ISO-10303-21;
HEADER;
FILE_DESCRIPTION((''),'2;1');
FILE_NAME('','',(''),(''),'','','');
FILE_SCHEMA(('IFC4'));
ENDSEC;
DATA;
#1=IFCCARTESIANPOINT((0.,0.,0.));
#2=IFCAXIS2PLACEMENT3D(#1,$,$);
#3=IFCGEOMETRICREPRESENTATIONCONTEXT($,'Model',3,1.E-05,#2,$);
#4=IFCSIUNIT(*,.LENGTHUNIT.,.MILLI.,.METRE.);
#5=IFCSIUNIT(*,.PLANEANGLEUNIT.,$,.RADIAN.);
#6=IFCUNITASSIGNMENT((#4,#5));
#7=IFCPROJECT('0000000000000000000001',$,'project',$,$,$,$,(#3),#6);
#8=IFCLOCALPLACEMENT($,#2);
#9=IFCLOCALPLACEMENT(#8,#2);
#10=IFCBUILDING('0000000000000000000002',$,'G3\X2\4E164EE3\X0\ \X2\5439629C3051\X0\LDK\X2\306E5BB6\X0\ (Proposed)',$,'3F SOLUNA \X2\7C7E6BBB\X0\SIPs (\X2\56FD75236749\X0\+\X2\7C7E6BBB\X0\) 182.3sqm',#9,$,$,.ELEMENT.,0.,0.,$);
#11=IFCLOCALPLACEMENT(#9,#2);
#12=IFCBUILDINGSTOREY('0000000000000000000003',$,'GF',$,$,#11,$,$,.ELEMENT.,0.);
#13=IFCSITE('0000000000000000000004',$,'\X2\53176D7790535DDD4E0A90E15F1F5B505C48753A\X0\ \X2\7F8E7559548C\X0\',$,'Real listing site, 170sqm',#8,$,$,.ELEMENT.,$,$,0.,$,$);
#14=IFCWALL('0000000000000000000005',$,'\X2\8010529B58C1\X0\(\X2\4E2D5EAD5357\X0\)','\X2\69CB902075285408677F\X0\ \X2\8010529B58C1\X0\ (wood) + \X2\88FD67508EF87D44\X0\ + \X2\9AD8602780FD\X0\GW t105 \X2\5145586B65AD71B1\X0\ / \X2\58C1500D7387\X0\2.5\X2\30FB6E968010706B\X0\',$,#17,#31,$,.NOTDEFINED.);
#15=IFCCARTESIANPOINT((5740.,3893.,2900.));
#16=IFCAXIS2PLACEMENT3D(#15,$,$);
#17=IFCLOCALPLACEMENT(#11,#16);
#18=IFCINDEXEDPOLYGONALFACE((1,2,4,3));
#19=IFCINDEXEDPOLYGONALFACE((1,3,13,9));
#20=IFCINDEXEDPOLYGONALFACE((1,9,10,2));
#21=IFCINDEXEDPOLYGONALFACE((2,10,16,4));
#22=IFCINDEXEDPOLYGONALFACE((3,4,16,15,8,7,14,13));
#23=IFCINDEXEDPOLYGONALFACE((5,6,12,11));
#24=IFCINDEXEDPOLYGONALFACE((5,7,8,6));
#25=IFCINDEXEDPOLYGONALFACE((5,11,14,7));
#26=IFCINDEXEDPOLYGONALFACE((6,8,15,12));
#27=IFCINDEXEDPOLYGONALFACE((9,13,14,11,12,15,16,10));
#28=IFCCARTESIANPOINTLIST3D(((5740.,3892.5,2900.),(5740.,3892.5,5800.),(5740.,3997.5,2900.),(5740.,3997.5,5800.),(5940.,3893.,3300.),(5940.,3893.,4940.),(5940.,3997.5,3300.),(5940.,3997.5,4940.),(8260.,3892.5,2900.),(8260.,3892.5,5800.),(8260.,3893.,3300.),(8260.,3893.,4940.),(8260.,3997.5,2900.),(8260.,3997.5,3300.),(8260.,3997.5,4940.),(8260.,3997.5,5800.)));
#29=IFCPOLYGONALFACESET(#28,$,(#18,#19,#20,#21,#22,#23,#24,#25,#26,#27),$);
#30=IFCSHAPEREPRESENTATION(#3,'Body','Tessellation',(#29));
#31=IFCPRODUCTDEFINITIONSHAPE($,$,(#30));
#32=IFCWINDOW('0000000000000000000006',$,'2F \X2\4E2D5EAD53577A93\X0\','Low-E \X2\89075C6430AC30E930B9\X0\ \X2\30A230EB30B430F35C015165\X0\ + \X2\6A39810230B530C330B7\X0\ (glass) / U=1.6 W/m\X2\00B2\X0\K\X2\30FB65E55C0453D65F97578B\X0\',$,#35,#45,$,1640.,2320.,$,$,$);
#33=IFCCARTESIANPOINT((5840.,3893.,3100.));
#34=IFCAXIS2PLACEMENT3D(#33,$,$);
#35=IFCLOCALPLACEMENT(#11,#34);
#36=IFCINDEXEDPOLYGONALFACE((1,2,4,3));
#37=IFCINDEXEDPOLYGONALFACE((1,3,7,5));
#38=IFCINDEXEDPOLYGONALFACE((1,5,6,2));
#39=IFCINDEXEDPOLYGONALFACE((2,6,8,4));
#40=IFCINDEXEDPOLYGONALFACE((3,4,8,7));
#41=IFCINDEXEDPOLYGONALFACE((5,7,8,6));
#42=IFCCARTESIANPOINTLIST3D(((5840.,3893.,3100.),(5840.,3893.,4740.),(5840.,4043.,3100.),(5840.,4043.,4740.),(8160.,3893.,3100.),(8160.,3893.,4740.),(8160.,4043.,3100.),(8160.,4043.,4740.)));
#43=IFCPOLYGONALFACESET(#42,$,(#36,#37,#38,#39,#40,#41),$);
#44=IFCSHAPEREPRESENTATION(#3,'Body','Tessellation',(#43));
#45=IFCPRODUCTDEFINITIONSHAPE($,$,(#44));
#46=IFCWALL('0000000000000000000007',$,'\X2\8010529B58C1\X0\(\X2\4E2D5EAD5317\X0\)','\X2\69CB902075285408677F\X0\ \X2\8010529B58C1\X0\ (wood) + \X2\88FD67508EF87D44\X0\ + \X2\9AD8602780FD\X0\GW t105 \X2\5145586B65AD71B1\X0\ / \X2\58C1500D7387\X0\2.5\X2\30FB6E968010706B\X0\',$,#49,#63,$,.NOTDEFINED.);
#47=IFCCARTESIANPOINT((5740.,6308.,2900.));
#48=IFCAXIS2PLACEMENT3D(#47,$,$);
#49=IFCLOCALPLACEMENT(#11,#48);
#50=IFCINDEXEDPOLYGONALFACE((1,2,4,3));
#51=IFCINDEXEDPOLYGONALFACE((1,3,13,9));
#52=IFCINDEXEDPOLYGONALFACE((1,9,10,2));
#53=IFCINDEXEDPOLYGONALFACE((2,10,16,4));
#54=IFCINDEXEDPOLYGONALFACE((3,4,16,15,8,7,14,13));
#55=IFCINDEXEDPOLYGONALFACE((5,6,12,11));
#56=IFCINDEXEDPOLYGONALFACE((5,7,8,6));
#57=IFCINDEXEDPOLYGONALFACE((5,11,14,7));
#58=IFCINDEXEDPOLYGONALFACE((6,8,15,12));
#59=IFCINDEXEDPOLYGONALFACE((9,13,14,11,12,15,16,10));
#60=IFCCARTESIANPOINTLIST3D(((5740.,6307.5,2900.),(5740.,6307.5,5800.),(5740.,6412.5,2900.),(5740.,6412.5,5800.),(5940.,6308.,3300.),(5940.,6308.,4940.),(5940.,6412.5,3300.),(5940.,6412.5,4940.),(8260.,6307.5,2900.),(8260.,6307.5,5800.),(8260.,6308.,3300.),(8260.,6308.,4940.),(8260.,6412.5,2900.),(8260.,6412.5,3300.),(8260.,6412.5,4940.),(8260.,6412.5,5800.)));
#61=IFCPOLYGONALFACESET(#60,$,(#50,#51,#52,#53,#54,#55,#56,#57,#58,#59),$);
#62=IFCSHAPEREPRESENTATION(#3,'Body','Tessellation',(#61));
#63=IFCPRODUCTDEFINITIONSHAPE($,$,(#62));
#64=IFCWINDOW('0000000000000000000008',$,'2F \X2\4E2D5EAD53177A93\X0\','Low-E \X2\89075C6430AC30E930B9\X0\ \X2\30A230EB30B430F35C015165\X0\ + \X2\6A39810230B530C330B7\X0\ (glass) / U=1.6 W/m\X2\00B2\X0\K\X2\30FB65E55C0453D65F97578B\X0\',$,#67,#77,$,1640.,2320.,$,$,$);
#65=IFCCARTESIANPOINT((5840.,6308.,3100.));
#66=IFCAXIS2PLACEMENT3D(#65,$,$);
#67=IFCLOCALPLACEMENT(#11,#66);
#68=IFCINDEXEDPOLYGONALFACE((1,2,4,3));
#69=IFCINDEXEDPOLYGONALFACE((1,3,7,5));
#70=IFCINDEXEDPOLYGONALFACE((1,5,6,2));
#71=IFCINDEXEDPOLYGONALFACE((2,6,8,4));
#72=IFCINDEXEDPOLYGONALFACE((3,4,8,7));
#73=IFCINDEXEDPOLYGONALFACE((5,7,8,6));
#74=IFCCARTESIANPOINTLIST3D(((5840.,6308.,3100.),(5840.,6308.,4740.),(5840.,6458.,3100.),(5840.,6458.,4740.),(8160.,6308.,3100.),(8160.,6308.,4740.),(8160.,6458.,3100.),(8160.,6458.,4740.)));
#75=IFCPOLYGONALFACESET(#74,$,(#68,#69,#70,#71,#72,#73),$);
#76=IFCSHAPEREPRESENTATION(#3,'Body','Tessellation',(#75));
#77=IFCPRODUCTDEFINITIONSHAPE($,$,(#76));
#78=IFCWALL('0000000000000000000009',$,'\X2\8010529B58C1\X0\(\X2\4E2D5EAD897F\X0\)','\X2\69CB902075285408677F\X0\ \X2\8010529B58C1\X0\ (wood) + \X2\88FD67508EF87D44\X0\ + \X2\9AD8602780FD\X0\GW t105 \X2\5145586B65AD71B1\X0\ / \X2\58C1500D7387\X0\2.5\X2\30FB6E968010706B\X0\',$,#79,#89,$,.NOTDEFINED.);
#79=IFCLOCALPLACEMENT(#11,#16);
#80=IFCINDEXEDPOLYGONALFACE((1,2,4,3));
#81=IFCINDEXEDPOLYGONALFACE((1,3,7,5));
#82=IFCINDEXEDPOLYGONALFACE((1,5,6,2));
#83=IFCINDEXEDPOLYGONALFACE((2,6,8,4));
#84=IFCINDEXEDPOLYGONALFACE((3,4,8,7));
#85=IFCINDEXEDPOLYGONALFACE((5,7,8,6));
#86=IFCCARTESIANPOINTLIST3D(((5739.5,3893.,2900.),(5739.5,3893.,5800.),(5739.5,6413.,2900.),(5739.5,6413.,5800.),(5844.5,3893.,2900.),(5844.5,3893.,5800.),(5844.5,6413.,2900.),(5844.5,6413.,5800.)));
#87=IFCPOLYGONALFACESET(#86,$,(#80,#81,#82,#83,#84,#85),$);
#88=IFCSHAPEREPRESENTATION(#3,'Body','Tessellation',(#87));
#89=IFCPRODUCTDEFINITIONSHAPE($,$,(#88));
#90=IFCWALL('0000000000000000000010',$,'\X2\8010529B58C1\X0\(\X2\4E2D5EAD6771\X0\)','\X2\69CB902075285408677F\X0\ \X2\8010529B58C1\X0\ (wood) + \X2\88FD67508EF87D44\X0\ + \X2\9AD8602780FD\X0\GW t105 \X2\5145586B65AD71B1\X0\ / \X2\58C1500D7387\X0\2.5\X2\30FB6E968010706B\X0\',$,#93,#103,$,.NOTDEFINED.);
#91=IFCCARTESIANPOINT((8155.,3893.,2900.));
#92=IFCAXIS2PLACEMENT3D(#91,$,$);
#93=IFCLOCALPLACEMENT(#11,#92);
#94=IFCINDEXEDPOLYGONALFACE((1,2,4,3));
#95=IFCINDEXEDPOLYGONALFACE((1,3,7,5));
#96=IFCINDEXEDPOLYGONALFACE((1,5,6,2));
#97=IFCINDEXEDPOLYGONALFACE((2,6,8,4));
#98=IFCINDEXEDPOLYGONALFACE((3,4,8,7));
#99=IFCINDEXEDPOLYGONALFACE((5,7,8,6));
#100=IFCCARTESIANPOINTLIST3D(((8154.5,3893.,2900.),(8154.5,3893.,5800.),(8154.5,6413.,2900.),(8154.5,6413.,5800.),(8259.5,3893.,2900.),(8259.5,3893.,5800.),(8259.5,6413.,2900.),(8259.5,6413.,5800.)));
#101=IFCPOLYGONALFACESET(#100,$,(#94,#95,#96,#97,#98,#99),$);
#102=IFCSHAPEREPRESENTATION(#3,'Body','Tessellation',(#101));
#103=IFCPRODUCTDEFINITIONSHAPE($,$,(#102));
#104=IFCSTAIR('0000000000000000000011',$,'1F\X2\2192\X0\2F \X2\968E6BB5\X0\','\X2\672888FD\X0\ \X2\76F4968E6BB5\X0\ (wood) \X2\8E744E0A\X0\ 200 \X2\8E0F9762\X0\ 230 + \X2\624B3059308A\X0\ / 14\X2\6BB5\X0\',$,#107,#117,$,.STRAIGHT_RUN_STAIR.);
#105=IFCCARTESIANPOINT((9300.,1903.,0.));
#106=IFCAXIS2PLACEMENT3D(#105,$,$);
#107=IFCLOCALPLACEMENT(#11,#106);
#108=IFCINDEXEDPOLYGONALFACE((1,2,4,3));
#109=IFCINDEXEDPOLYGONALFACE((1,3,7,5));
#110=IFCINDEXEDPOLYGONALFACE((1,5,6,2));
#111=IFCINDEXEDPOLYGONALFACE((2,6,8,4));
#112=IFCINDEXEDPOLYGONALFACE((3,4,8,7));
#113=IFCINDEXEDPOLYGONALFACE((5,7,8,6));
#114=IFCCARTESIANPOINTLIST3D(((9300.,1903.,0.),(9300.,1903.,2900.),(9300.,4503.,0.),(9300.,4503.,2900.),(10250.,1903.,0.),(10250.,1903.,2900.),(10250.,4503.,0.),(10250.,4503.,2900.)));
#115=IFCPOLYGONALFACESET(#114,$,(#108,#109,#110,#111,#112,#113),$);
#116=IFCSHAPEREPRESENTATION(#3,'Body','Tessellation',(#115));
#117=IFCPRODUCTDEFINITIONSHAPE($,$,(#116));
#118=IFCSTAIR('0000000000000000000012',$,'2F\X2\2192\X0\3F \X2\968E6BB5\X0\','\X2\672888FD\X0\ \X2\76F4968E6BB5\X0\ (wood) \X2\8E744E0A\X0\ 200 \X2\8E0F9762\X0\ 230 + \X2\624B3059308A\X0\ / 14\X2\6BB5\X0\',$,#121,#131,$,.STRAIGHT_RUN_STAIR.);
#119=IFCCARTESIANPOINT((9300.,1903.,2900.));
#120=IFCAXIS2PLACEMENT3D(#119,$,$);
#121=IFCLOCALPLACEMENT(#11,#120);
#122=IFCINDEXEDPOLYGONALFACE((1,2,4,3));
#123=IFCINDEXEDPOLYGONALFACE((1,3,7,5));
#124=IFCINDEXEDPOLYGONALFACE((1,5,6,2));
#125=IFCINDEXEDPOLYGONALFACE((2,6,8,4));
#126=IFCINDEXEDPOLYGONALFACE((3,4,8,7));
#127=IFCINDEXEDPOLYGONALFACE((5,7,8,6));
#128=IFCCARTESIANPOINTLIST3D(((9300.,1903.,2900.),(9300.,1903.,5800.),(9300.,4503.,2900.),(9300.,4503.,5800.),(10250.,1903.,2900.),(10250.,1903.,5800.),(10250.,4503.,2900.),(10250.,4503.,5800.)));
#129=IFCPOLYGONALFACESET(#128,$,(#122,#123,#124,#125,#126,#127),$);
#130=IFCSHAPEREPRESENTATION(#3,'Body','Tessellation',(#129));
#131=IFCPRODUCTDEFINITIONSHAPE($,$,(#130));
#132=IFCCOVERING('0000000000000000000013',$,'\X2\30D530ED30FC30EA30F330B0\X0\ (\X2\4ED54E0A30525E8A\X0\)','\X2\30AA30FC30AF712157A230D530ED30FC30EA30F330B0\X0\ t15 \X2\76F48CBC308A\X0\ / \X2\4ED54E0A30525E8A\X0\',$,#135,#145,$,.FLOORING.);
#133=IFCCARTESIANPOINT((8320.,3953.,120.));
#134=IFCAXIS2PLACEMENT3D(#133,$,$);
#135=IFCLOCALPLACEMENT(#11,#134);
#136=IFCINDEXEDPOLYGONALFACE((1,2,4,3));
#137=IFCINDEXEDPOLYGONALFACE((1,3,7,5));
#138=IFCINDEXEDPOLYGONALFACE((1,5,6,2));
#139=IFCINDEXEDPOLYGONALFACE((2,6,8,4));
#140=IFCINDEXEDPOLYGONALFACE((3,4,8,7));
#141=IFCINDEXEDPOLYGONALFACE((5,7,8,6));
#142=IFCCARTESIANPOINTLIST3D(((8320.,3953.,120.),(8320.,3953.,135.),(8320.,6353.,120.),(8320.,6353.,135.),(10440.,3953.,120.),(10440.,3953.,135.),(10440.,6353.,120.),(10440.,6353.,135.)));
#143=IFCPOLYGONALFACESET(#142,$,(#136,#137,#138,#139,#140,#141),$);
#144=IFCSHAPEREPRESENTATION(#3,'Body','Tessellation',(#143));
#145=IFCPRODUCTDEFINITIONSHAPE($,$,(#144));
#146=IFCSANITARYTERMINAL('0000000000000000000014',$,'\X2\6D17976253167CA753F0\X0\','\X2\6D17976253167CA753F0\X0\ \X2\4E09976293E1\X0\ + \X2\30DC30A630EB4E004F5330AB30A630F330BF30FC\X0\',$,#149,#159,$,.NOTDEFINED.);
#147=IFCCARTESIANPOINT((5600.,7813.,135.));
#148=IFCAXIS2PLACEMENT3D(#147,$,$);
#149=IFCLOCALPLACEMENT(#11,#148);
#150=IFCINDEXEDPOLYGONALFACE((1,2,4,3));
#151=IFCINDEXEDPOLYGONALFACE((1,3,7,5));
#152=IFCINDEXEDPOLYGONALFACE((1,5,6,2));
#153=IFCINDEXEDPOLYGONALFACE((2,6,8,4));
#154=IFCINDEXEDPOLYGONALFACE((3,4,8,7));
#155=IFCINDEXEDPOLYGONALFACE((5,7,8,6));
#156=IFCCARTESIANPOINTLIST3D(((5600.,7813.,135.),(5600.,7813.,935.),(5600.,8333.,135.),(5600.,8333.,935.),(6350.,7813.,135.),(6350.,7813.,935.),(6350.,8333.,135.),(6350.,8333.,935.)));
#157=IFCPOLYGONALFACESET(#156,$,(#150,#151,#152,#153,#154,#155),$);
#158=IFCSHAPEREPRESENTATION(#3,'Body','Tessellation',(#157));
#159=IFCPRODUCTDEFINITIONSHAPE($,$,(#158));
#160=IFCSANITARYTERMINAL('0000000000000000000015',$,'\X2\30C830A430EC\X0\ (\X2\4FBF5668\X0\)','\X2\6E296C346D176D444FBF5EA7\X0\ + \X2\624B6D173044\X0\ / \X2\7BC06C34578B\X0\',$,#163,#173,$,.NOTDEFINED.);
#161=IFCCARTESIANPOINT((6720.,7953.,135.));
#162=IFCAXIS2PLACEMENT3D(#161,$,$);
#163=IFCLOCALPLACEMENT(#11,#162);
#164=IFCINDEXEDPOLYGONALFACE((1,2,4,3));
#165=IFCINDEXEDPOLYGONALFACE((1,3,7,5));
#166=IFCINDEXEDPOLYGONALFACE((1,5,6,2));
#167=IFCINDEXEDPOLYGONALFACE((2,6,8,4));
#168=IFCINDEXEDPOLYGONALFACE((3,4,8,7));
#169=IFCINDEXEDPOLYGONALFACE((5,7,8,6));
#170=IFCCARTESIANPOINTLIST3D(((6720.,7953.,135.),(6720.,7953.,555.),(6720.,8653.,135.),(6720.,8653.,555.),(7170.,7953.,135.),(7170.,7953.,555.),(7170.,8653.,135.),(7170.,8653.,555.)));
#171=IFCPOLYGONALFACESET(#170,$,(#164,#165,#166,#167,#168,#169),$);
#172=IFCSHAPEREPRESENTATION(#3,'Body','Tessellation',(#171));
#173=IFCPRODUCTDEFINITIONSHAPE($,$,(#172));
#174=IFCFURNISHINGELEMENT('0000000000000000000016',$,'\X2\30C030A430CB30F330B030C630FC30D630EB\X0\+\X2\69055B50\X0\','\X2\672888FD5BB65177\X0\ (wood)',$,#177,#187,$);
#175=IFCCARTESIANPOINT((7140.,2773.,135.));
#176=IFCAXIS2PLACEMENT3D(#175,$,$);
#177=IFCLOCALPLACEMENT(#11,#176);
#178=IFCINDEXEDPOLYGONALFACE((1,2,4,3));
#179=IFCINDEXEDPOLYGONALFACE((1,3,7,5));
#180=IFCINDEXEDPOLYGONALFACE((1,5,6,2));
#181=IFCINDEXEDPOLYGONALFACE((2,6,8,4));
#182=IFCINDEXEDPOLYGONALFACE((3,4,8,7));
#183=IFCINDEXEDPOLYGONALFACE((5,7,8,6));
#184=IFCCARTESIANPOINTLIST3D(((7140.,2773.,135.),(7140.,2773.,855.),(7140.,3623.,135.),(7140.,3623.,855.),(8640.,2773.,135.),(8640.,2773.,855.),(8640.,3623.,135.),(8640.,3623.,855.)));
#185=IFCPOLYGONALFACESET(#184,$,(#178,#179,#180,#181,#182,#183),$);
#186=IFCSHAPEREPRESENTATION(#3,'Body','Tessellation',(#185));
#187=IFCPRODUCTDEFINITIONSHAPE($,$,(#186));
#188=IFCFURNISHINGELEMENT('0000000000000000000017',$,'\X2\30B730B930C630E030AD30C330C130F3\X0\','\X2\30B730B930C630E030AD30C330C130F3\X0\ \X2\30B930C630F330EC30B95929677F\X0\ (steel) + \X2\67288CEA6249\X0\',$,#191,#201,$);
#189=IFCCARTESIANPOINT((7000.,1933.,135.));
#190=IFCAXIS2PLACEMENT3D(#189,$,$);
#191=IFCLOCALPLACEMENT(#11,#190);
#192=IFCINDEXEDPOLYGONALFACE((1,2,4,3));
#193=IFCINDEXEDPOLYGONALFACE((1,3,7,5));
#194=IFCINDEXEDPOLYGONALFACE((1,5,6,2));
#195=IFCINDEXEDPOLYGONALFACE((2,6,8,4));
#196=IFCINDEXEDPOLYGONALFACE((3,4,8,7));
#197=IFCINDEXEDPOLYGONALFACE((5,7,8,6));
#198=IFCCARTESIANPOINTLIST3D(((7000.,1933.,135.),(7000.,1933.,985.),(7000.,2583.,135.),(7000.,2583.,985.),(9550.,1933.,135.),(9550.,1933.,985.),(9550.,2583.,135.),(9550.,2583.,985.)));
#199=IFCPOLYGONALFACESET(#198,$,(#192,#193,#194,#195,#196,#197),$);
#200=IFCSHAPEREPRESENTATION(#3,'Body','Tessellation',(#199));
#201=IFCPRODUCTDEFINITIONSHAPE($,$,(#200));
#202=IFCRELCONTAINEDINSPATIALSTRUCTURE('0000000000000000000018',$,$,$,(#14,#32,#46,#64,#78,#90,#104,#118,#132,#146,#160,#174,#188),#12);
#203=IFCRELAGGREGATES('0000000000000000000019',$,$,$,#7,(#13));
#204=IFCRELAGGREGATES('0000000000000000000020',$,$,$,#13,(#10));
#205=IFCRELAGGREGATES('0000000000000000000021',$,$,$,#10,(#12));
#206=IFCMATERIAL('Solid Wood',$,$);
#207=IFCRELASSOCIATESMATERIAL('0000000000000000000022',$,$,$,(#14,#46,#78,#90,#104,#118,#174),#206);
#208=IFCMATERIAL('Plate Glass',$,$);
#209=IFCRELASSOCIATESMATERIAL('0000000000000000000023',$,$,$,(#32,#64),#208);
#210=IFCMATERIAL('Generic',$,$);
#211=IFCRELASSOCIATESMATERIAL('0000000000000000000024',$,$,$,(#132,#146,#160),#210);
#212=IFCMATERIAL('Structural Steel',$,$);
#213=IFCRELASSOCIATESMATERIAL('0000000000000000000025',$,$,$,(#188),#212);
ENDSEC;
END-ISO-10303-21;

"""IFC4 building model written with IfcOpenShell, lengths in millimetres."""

from ifc_helpers import new_model, si_unit, frame, frame_2d, origin, place, context, project, spatial, rectangle, extrude, material, element, fill, save


model = new_model("IFC4")

# Units and contexts
model_context = context("Model", 3, precision=1e-05, world=origin())
ifc_project = project(units=[si_unit("LENGTHUNIT", "METRE", prefix="MILLI"), si_unit("PLANEANGLEUNIT", "RADIAN")], contexts=[model_context])

# Site, building, storey
site_placement = place(None, origin())
site = spatial("IfcSite", under=ifc_project, at=site_placement, Name="北海道川上郡弟子屈町 美留和", ObjectType="Real listing site, 170sqm", CompositionType="ELEMENT", RefElevation=0.0)
building_placement = place(site_placement, origin())
building = spatial("IfcBuilding", under=site, at=building_placement, Name="G3世代 吹抜けLDKの家 (Proposed)", ObjectType="3F SOLUNA 籾殻SIPs (国産杉+籾殻) 182.3sqm", CompositionType="ELEMENT", ElevationOfRefHeight=0.0, ElevationOfTerrain=0.0)
storey_placement = place(building_placement, origin())
storey = spatial("IfcBuildingStorey", under=building, at=storey_placement, Name="GF", CompositionType="ELEMENT", Elevation=0.0)

# Shared definitions
ifc_material_1 = material(Name="Solid Wood")

# Shared definitions
ifc_material_2 = material(Name="Plate Glass")

# Walls, openings, windows
wall_1_placement = place(storey_placement, frame((5740.0, 3893.0, 2900.0)))
wall_1 = element("IfcWall", 1, at=wall_1_placement, inside=storey, material=ifc_material_1, Name="耐力壁(中庭南)", Description="構造用合板 耐力壁 (wood) + 製材軸組 + 高性能GW t105 充填断熱 / 壁倍率2.5・準耐火", PredefinedType="NOTDEFINED", context=model_context, shape_type="SweptSolid", body=[
    extrude(rectangle(XDim=2520.0, YDim=105.0, at=frame_2d((1260.0, 52.0))), frame((5740.0, 3893.0, 2900.0)), (0.0, 0.0, 1.0), 2900.0),
])
opening_1_placement = place(storey_placement, frame((5840.0, 3893.0, 3100.0)))
opening_1 = element("IfcOpeningElement", 2, at=opening_1_placement, cuts=wall_1, PredefinedType="NOTDEFINED", context=model_context, shape_type="SweptSolid", body=[
    extrude(rectangle(XDim=2320.0, YDim=150.0, at=frame_2d((1160.0, 75.0))), frame((5840.0, 3893.0, 3100.0)), (0.0, 0.0, 1.0), 1640.0),
])
window_1_placement = place(storey_placement, frame((5840.0, 3893.0, 3100.0)))
window_1 = element("IfcWindow", 3, at=window_1_placement, inside=storey, material=ifc_material_2, Name="2F 中庭南窓", Description="Low-E 複層ガラス アルゴン封入 + 樹脂サッシ (glass) / U=1.6 W/m²K・日射取得型", OverallHeight=1640.0, OverallWidth=2320.0, context=model_context, shape_type="SweptSolid", body=[
    extrude(rectangle(XDim=2320.0, YDim=150.0, at=frame_2d((1160.0, 75.0))), frame((5840.0, 3893.0, 3100.0)), (0.0, 0.0, 1.0), 1640.0),
])
fill(opening_1, window_1)
wall_2_placement = place(storey_placement, frame((5740.0, 6308.0, 2900.0)))
wall_2 = element("IfcWall", 4, at=wall_2_placement, inside=storey, material=ifc_material_1, Name="耐力壁(中庭北)", Description="構造用合板 耐力壁 (wood) + 製材軸組 + 高性能GW t105 充填断熱 / 壁倍率2.5・準耐火", PredefinedType="NOTDEFINED", context=model_context, shape_type="SweptSolid", body=[
    extrude(rectangle(XDim=2520.0, YDim=105.0, at=frame_2d((1260.0, 52.0))), frame((5740.0, 6308.0, 2900.0)), (0.0, 0.0, 1.0), 2900.0),
])
opening_2_placement = place(storey_placement, frame((5840.0, 6308.0, 3100.0)))
opening_2 = element("IfcOpeningElement", 5, at=opening_2_placement, cuts=wall_2, PredefinedType="NOTDEFINED", context=model_context, shape_type="SweptSolid", body=[
    extrude(rectangle(XDim=2320.0, YDim=150.0, at=frame_2d((1160.0, 75.0))), frame((5840.0, 6308.0, 3100.0)), (0.0, 0.0, 1.0), 1640.0),
])
window_2_placement = place(storey_placement, frame((5840.0, 6308.0, 3100.0)))
window_2 = element("IfcWindow", 6, at=window_2_placement, inside=storey, material=ifc_material_2, Name="2F 中庭北窓", Description="Low-E 複層ガラス アルゴン封入 + 樹脂サッシ (glass) / U=1.6 W/m²K・日射取得型", OverallHeight=1640.0, OverallWidth=2320.0, context=model_context, shape_type="SweptSolid", body=[
    extrude(rectangle(XDim=2320.0, YDim=150.0, at=frame_2d((1160.0, 75.0))), frame((5840.0, 6308.0, 3100.0)), (0.0, 0.0, 1.0), 1640.0),
])
fill(opening_2, window_2)

# Walls
wall_3_placement = place(storey_placement, frame((5740.0, 3893.0, 2900.0)))
element("IfcWall", 7, at=wall_3_placement, inside=storey, material=ifc_material_1, Name="耐力壁(中庭西)", Description="構造用合板 耐力壁 (wood) + 製材軸組 + 高性能GW t105 充填断熱 / 壁倍率2.5・準耐火", PredefinedType="NOTDEFINED", context=model_context, shape_type="SweptSolid", body=[
    extrude(rectangle(XDim=105.0, YDim=2520.0, at=frame_2d((52.0, 1260.0))), frame((5740.0, 3893.0, 2900.0)), (0.0, 0.0, 1.0), 2900.0),
])
wall_4_placement = place(storey_placement, frame((8155.0, 3893.0, 2900.0)))
element("IfcWall", 8, at=wall_4_placement, inside=storey, material=ifc_material_1, Name="耐力壁(中庭東)", Description="構造用合板 耐力壁 (wood) + 製材軸組 + 高性能GW t105 充填断熱 / 壁倍率2.5・準耐火", PredefinedType="NOTDEFINED", context=model_context, shape_type="SweptSolid", body=[
    extrude(rectangle(XDim=105.0, YDim=2520.0, at=frame_2d((52.0, 1260.0))), frame((8155.0, 3893.0, 2900.0)), (0.0, 0.0, 1.0), 2900.0),
])

# Stairs
stair_1_placement = place(storey_placement, frame((9300.0, 1903.0, 0.0)))
element("IfcStair", 9, at=stair_1_placement, inside=storey, material=ifc_material_1, Name="1F→2F 階段", Description="木製 直階段 (wood) 蹴上 200 踏面 230 + 手すり / 14段", PredefinedType="STRAIGHT_RUN_STAIR", context=model_context, shape_type="SweptSolid", body=[
    extrude(rectangle(XDim=950.0, YDim=2600.0, at=frame_2d((475.0, 1300.0))), frame((9300.0, 1903.0, 0.0)), (0.0, 0.0, 1.0), 2900.0),
])
stair_2_placement = place(storey_placement, frame((9300.0, 1903.0, 2900.0)))
element("IfcStair", 10, at=stair_2_placement, inside=storey, material=ifc_material_1, Name="2F→3F 階段", Description="木製 直階段 (wood) 蹴上 200 踏面 230 + 手すり / 14段", PredefinedType="STRAIGHT_RUN_STAIR", context=model_context, shape_type="SweptSolid", body=[
    extrude(rectangle(XDim=950.0, YDim=2600.0, at=frame_2d((475.0, 1300.0))), frame((9300.0, 1903.0, 2900.0)), (0.0, 0.0, 1.0), 2900.0),
])

# Covering
ifc_material_3 = material(Name="Generic")
covering_placement = place(storey_placement, frame((8320.0, 3953.0, 120.0)))
element("IfcCovering", 11, at=covering_placement, inside=storey, material=ifc_material_3, Name="フローリング (仕上げ床)", Description="オーク無垢フローリング t15 直貼り / 仕上げ床", PredefinedType="FLOORING", context=model_context, shape_type="SweptSolid", body=[
    extrude(rectangle(XDim=2120.0, YDim=2400.0, at=frame_2d((1060.0, 1200.0))), frame((8320.0, 3953.0, 120.0)), (0.0, 0.0, 1.0), 15.0),
])

# Sanitary terminals
sanitary_terminal_1_placement = place(storey_placement, frame((5600.0, 7813.0, 135.0)))
element("IfcSanitaryTerminal", 12, at=sanitary_terminal_1_placement, inside=storey, material=ifc_material_3, Name="洗面化粧台", Description="洗面化粧台 三面鏡 + ボウル一体カウンター", PredefinedType="NOTDEFINED", context=model_context, shape_type="SweptSolid", body=[
    extrude(rectangle(XDim=750.0, YDim=520.0, at=frame_2d((375.0, 260.0))), frame((5600.0, 7813.0, 135.0)), (0.0, 0.0, 1.0), 800.0),
])
sanitary_terminal_2_placement = place(storey_placement, frame((6720.0, 7953.0, 135.0)))
element("IfcSanitaryTerminal", 13, at=sanitary_terminal_2_placement, inside=storey, material=ifc_material_3, Name="トイレ (便器)", Description="温水洗浄便座 + 手洗い / 節水型", PredefinedType="NOTDEFINED", context=model_context, shape_type="SweptSolid", body=[
    extrude(rectangle(XDim=450.0, YDim=700.0, at=frame_2d((225.0, 350.0))), frame((6720.0, 7953.0, 135.0)), (0.0, 0.0, 1.0), 420.0),
])

# Furnishing elements
furnishing_1_placement = place(storey_placement, frame((7140.0, 2773.0, 135.0)))
element("IfcFurnishingElement", 14, at=furnishing_1_placement, inside=storey, material=ifc_material_1, Name="ダイニングテーブル+椅子", Description="木製家具 (wood)", context=model_context, shape_type="SweptSolid", body=[
    extrude(rectangle(XDim=1500.0, YDim=850.0, at=frame_2d((750.0, 425.0))), frame((7140.0, 2773.0, 135.0)), (0.0, 0.0, 1.0), 720.0),
])
ifc_material_4 = material(Name="Structural Steel")
furnishing_2_placement = place(storey_placement, frame((7000.0, 1933.0, 135.0)))
element("IfcFurnishingElement", 15, at=furnishing_2_placement, inside=storey, material=ifc_material_4, Name="システムキッチン", Description="システムキッチン ステンレス天板 (steel) + 木質扉", context=model_context, shape_type="SweptSolid", body=[
    extrude(rectangle(XDim=2550.0, YDim=650.0, at=frame_2d((1275.0, 325.0))), frame((7000.0, 1933.0, 135.0)), (0.0, 0.0, 1.0), 850.0),
])

save(model, "model.ifc")
